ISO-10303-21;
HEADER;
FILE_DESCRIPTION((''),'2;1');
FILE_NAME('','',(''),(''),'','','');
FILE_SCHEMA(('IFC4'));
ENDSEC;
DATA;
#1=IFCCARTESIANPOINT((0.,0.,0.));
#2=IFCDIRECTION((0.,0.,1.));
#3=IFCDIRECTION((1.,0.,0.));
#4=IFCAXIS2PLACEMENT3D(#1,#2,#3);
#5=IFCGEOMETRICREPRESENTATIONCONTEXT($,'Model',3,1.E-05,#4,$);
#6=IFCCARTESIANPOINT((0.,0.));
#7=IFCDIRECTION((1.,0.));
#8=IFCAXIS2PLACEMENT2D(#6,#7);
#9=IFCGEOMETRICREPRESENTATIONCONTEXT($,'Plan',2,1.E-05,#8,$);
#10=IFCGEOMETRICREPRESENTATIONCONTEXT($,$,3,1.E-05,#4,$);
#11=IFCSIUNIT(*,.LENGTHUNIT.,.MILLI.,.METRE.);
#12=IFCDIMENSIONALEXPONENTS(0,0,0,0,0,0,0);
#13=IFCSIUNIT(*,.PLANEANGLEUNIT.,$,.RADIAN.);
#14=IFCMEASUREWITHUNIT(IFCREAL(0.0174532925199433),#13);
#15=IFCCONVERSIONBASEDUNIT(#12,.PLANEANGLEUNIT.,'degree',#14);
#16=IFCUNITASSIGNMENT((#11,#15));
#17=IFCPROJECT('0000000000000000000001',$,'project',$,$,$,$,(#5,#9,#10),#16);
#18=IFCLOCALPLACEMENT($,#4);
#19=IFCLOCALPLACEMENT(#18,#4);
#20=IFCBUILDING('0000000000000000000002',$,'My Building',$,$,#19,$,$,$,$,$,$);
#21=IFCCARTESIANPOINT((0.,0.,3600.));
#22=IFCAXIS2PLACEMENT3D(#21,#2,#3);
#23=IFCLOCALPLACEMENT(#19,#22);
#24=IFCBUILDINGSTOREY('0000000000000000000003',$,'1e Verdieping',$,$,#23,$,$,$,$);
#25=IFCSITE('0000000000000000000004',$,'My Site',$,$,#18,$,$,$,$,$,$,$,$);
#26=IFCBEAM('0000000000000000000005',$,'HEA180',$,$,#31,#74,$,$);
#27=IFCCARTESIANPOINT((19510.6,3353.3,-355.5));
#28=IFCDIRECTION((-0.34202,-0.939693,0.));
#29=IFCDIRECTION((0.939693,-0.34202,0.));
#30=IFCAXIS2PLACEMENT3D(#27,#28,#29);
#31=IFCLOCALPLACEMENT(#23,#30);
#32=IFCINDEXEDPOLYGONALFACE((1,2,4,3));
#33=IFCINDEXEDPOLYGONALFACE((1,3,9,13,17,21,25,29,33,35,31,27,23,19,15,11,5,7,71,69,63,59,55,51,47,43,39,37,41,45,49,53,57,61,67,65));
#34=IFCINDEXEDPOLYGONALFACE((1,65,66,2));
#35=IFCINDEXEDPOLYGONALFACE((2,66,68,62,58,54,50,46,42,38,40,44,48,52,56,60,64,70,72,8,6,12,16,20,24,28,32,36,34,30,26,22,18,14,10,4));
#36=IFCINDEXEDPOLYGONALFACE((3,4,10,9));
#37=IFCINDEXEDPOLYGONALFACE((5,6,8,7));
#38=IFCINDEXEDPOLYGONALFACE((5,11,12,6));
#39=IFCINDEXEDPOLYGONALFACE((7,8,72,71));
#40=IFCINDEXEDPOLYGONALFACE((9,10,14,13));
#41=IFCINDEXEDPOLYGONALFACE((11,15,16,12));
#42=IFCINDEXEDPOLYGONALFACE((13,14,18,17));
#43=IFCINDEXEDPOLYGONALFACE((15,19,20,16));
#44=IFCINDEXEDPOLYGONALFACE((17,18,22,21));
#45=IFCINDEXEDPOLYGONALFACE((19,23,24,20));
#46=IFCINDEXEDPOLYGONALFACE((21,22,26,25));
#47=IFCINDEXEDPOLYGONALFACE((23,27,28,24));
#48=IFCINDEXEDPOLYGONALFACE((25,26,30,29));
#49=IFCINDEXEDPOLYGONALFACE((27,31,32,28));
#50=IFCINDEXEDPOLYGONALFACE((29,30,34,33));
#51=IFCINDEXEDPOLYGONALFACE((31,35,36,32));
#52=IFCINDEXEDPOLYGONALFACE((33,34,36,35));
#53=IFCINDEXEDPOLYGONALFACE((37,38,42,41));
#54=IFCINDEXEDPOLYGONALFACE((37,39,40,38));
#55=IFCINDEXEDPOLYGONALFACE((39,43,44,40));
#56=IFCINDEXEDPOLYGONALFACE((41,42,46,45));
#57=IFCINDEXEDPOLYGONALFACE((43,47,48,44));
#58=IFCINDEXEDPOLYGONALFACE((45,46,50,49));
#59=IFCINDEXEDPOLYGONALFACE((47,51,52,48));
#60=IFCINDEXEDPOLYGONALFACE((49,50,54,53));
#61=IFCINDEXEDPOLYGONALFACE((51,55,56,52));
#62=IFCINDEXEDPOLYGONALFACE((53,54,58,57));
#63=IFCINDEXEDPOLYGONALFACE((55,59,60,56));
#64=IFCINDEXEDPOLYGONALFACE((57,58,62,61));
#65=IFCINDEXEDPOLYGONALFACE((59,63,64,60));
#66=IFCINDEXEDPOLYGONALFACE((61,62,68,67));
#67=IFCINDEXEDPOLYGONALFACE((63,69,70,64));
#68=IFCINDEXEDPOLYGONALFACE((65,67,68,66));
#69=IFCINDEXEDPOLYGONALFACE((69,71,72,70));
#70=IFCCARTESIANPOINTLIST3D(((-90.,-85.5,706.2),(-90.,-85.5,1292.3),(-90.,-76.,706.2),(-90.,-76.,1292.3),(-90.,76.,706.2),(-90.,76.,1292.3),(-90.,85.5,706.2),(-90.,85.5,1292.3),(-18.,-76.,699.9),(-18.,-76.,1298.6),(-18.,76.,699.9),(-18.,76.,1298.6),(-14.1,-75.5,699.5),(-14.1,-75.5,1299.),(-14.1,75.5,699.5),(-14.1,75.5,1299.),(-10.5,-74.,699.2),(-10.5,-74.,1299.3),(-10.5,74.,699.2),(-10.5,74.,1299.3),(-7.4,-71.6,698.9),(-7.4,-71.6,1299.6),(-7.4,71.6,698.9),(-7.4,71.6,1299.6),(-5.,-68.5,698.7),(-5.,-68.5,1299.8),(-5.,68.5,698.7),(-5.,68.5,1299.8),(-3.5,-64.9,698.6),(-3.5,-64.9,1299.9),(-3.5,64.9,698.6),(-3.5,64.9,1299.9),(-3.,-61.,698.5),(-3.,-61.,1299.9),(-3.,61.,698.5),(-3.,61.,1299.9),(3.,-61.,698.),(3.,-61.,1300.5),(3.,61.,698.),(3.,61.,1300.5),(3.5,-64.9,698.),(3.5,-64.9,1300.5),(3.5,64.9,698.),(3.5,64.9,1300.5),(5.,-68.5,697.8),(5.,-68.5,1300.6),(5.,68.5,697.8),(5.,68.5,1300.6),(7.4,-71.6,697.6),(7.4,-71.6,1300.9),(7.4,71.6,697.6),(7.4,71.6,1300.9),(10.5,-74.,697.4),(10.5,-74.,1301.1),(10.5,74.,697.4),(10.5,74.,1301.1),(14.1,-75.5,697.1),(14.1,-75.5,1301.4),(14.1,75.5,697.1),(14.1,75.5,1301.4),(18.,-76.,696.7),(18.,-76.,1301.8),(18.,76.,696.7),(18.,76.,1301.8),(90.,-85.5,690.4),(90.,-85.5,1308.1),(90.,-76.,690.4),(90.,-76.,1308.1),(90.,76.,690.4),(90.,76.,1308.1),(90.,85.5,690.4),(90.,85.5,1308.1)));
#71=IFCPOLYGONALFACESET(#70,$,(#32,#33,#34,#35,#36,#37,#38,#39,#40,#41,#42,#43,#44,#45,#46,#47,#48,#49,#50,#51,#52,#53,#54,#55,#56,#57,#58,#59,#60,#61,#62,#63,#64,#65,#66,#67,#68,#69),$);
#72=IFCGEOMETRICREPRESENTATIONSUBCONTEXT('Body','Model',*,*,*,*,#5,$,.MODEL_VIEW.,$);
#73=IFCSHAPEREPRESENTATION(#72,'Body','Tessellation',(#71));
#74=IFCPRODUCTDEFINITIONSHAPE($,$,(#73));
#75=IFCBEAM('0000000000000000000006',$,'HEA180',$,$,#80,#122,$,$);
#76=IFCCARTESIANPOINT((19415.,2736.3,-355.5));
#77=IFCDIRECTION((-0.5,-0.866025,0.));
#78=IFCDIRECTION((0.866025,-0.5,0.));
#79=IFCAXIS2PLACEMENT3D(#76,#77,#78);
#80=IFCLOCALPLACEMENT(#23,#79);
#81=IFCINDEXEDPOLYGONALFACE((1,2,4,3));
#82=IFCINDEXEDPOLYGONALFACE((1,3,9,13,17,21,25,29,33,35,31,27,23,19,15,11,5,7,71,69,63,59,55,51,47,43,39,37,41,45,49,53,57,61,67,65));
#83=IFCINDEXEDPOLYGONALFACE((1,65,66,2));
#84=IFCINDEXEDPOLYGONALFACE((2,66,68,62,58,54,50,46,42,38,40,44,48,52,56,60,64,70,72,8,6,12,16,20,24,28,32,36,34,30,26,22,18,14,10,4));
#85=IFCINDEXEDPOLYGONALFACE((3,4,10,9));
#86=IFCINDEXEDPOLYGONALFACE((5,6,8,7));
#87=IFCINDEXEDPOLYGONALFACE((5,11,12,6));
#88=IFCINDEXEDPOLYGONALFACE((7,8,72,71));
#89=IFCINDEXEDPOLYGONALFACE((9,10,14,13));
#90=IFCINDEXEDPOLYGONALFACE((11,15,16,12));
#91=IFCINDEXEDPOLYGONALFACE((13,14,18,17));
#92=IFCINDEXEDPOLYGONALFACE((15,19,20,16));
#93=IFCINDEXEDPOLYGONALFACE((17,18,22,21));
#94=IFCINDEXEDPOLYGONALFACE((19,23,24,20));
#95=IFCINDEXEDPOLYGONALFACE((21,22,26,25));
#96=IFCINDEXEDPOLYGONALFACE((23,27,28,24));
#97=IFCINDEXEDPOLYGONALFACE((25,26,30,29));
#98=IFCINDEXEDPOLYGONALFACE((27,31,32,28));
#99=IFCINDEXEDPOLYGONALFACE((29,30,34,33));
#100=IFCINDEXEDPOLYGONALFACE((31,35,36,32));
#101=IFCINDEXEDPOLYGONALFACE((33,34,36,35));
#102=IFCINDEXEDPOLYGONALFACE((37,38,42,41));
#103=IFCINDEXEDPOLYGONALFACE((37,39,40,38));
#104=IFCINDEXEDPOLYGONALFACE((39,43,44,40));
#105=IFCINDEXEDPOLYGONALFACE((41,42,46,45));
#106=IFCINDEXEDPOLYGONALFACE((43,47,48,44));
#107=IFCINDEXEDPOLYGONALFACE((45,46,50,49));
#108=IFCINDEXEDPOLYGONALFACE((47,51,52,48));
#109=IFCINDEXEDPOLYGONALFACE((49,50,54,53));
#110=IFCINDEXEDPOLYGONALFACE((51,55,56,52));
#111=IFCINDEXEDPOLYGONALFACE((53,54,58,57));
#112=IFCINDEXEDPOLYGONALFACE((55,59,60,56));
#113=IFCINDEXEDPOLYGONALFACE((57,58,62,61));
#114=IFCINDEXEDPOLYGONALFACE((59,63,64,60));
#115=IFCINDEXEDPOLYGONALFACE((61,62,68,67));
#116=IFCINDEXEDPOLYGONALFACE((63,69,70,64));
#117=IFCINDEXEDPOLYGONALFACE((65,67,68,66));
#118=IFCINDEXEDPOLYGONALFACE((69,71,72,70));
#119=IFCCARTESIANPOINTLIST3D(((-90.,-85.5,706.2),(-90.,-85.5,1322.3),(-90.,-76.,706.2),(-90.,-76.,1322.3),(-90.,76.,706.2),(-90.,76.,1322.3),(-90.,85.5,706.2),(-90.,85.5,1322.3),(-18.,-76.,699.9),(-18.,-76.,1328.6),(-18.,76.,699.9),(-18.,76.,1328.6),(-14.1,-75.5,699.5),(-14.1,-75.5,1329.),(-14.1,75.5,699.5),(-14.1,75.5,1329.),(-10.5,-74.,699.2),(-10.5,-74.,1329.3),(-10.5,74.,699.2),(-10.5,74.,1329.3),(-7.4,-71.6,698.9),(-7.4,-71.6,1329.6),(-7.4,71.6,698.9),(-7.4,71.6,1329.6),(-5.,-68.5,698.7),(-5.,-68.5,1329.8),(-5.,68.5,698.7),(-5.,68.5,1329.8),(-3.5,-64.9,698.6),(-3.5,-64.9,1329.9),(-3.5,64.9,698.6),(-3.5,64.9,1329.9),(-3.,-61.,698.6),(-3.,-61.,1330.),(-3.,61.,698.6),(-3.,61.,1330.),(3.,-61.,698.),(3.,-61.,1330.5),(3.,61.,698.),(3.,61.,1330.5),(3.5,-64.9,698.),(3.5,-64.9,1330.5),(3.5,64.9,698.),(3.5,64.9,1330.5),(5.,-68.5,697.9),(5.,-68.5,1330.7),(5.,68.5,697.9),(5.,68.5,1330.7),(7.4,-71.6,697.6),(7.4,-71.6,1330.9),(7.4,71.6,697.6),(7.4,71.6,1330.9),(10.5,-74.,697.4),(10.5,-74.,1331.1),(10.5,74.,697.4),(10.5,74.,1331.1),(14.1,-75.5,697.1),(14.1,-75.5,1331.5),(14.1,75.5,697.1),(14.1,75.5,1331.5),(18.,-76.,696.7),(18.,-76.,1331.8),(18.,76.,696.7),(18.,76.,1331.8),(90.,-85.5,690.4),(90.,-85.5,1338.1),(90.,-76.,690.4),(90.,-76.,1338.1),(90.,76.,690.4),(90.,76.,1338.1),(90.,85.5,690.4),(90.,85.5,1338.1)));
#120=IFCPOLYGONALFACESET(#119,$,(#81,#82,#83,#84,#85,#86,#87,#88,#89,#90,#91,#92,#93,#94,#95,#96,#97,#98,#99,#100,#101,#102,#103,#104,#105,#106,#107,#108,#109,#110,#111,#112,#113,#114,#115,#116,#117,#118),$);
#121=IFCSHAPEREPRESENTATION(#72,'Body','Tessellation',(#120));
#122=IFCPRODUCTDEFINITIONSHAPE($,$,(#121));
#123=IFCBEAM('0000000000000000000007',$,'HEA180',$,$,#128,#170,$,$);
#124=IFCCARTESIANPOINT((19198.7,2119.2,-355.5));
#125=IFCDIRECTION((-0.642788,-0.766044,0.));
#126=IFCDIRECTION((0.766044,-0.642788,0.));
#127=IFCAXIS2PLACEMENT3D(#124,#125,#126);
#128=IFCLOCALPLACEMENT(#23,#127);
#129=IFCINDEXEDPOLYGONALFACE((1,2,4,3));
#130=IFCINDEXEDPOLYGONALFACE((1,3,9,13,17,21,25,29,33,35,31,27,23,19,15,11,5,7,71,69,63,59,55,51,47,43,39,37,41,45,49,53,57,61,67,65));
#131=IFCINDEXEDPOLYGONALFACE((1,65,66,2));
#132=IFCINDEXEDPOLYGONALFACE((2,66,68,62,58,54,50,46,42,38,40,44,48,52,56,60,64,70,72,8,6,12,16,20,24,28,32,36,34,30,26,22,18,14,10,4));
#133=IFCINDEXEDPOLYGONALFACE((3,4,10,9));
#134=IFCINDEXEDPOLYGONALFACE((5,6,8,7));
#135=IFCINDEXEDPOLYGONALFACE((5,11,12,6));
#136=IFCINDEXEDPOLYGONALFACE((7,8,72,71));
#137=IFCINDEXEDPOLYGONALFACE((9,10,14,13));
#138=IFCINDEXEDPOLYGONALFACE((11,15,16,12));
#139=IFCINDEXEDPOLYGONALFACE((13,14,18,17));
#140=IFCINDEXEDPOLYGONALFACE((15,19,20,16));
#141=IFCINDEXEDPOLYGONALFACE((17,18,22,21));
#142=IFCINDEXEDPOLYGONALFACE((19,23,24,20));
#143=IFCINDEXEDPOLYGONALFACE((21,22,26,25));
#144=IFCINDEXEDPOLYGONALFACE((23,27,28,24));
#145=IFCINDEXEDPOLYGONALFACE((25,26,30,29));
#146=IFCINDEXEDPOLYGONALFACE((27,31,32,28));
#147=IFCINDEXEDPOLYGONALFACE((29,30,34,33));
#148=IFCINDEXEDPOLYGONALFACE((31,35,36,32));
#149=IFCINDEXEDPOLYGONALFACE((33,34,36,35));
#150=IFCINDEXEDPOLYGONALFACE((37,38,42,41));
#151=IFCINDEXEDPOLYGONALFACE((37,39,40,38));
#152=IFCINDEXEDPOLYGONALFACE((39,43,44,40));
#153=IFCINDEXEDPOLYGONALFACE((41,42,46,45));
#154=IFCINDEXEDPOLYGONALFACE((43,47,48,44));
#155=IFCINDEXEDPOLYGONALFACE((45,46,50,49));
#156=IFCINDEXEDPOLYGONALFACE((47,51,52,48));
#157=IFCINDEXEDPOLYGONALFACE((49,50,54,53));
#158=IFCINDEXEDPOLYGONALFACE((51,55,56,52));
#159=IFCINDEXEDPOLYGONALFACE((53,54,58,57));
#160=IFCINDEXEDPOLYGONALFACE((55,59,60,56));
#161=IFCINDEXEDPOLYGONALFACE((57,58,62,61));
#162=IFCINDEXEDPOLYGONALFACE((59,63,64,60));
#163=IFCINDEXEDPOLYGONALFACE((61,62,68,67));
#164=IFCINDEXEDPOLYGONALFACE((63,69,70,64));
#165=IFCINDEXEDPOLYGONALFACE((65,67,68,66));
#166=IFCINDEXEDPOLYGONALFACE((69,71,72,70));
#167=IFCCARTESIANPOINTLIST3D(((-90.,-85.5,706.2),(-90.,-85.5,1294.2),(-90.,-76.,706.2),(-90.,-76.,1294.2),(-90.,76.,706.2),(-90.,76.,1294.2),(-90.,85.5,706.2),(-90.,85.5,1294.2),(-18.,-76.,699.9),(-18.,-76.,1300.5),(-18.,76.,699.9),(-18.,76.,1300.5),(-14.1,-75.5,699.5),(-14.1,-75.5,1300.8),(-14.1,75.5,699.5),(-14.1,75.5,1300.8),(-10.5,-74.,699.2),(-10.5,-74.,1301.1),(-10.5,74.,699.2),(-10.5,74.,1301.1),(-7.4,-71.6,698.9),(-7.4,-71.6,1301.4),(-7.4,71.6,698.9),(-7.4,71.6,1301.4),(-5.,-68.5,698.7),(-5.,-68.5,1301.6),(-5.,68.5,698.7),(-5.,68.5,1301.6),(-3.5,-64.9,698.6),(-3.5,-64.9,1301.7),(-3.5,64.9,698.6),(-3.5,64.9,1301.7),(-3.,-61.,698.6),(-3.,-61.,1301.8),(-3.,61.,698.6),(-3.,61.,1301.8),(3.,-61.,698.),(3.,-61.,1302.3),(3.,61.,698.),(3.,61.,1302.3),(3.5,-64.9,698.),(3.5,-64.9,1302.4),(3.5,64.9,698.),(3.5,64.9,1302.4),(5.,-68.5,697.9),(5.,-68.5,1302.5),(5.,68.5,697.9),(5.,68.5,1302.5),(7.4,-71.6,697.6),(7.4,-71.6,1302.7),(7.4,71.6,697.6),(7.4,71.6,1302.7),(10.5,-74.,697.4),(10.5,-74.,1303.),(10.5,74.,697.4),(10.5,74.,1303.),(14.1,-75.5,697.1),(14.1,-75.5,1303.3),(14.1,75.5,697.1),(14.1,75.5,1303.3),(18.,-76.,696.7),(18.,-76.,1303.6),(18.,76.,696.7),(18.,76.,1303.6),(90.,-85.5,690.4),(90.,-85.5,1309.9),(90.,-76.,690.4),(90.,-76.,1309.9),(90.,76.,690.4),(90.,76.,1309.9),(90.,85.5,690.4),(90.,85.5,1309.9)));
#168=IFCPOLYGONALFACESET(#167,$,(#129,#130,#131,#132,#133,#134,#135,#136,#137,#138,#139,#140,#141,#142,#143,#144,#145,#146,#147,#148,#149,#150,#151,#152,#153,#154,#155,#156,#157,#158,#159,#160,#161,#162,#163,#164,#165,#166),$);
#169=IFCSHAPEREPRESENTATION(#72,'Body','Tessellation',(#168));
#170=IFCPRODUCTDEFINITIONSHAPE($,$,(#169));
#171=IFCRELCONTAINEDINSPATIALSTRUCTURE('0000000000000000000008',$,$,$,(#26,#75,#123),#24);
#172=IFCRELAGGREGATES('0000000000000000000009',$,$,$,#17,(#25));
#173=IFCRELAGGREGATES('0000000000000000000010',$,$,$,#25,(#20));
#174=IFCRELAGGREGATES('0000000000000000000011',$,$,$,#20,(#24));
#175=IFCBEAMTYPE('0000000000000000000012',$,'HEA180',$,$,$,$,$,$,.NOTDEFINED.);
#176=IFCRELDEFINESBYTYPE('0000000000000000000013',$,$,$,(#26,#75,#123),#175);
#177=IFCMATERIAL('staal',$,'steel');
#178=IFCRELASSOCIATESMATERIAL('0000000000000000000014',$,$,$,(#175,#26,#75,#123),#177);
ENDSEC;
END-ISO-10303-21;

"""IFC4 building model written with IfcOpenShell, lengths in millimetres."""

from ifc_helpers import new_model, entity, si_unit, converted_unit, frame, origin_with_axes, origin_2d_with_axis, place, context, subcontext, project, spatial, i_section, extrude, clip, halfspace, material, material_profile, profile_set, profile_usage, type_object, element, save


model = new_model("IFC4")

# Units and contexts
model_context = context("Model", 3, precision=1e-05, world=origin_with_axes())
plan_context = context("Plan", 2, precision=1e-05, world=origin_2d_with_axis())
context_of_model = context(None, 3, precision=1e-05, world=origin_with_axes())
body_context = subcontext(model_context, "Body", "Model", "MODEL_VIEW")
ifc_project = project(units=[si_unit("LENGTHUNIT", "METRE", prefix="MILLI"), converted_unit("PLANEANGLEUNIT", "degree", entity("IfcReal", 0.0174532925199433), si_unit("PLANEANGLEUNIT", "RADIAN"), dimensions=[0, 0, 0, 0, 0, 0, 0])], contexts=[model_context, plan_context, context_of_model])

# Site, building, storey
site_placement = place(None, origin_with_axes())
site = spatial("IfcSite", under=ifc_project, at=site_placement, Name="My Site")
building_placement = place(site_placement, origin_with_axes())
building = spatial("IfcBuilding", under=site, at=building_placement, Name="My Building")
storey_placement = place(building_placement, frame((0.0, 0.0, 3600.0), z_axis=(0.0, 0.0, 1.0), x_axis=(1.0, 0.0, 0.0)))
storey = spatial("IfcBuildingStorey", under=building, at=storey_placement, Name="1e Verdieping")

# Shared definitions
ifc_material = material(Name="staal", Category="steel")

# Beams
ifc_material_profile_1 = material_profile(ifc_material, i_section(OverallWidth=180.0, OverallDepth=171.0, WebThickness=6.0, FlangeThickness=9.5, FilletRadius=15.0))
ifc_profile_set_1 = profile_set([ifc_material_profile_1], Name="HEA180")
beam_type_1 = type_object("IfcBeamType", Name="HEA180", PredefinedType="NOTDEFINED", material=ifc_profile_set_1)
ifc_profile_usage_1 = profile_usage(ifc_profile_set_1)
beam_1_placement = place(storey_placement, frame((19510.6, 3353.3, -355.5), z_axis=(-0.34202, -0.939693, 0.0), x_axis=(0.939693, -0.34202, 0.0)))
element("IfcBeam", 1, at=beam_1_placement, inside=storey, type_object=beam_type_1, material=ifc_profile_usage_1, Name="HEA180", context=body_context, shape_type="Clipping", body=[
    clip(clip(extrude(i_section(OverallWidth=180.0, OverallDepth=171.0, WebThickness=6.0, FlangeThickness=9.5, FilletRadius=15.0), origin_with_axes(), (0.0, 0.0, 1.0), 1998.5), halfspace(frame((90.0, -3254.0, 690.4), z_axis=(-0.087136, 0.0, -0.996196), x_axis=(0.0, 1.0, 0.0)), False)), halfspace(frame((90.0, -3254.0, 1308.1), z_axis=(-0.087123, 0.0, 0.996197), x_axis=(-0.000001, 1.0, 0.0)), False)),
])
ifc_profile_usage_2 = profile_usage(ifc_profile_set_1)
beam_2_placement = place(storey_placement, frame((19415.0, 2736.3, -355.5), z_axis=(-0.5, -0.866025, 0.0), x_axis=(0.866025, -0.5, 0.0)))
element("IfcBeam", 2, at=beam_2_placement, inside=storey, type_object=beam_type_1, material=ifc_profile_usage_2, Name="HEA180", context=body_context, shape_type="Clipping", body=[
    clip(clip(extrude(i_section(OverallWidth=180.0, OverallDepth=171.0, WebThickness=6.0, FlangeThickness=9.5, FilletRadius=15.0), origin_with_axes(), (0.0, 0.0, 1.0), 2028.5), halfspace(frame((90.0, -3254.0, 690.4), z_axis=(-0.087187, 0.0, -0.996192), x_axis=(0.000001, 1.0, 0.0)), False)), halfspace(frame((90.0, -3254.0, 1338.1), z_axis=(-0.087204, 0.0, 0.99619), x_axis=(-0.000001, 1.0, 0.0)), False)),
])
ifc_profile_usage_3 = profile_usage(ifc_profile_set_1)
beam_3_placement = place(storey_placement, frame((19198.7, 2119.2, -355.5), z_axis=(-0.642788, -0.766044, 0.0), x_axis=(0.766044, -0.642788, 0.0)))
element("IfcBeam", 3, at=beam_3_placement, inside=storey, type_object=beam_type_1, material=ifc_profile_usage_3, Name="HEA180", context=body_context, shape_type="Clipping", body=[
    clip(clip(extrude(i_section(OverallWidth=180.0, OverallDepth=171.0, WebThickness=6.0, FlangeThickness=9.5, FilletRadius=15.0), origin_with_axes(), (0.0, 0.0, 1.0), 2000.3), halfspace(frame((90.0, -3254.0, 690.4), z_axis=(-0.087149, 0.0, -0.996195), x_axis=(0.000001, 1.0, 0.0)), False)), halfspace(frame((90.0, -3254.0, 1309.9), z_axis=(-0.087193, 0.0, 0.996191), x_axis=(-0.000001, 1.0, 0.0)), False)),
])

save(model, "model.ifc")
